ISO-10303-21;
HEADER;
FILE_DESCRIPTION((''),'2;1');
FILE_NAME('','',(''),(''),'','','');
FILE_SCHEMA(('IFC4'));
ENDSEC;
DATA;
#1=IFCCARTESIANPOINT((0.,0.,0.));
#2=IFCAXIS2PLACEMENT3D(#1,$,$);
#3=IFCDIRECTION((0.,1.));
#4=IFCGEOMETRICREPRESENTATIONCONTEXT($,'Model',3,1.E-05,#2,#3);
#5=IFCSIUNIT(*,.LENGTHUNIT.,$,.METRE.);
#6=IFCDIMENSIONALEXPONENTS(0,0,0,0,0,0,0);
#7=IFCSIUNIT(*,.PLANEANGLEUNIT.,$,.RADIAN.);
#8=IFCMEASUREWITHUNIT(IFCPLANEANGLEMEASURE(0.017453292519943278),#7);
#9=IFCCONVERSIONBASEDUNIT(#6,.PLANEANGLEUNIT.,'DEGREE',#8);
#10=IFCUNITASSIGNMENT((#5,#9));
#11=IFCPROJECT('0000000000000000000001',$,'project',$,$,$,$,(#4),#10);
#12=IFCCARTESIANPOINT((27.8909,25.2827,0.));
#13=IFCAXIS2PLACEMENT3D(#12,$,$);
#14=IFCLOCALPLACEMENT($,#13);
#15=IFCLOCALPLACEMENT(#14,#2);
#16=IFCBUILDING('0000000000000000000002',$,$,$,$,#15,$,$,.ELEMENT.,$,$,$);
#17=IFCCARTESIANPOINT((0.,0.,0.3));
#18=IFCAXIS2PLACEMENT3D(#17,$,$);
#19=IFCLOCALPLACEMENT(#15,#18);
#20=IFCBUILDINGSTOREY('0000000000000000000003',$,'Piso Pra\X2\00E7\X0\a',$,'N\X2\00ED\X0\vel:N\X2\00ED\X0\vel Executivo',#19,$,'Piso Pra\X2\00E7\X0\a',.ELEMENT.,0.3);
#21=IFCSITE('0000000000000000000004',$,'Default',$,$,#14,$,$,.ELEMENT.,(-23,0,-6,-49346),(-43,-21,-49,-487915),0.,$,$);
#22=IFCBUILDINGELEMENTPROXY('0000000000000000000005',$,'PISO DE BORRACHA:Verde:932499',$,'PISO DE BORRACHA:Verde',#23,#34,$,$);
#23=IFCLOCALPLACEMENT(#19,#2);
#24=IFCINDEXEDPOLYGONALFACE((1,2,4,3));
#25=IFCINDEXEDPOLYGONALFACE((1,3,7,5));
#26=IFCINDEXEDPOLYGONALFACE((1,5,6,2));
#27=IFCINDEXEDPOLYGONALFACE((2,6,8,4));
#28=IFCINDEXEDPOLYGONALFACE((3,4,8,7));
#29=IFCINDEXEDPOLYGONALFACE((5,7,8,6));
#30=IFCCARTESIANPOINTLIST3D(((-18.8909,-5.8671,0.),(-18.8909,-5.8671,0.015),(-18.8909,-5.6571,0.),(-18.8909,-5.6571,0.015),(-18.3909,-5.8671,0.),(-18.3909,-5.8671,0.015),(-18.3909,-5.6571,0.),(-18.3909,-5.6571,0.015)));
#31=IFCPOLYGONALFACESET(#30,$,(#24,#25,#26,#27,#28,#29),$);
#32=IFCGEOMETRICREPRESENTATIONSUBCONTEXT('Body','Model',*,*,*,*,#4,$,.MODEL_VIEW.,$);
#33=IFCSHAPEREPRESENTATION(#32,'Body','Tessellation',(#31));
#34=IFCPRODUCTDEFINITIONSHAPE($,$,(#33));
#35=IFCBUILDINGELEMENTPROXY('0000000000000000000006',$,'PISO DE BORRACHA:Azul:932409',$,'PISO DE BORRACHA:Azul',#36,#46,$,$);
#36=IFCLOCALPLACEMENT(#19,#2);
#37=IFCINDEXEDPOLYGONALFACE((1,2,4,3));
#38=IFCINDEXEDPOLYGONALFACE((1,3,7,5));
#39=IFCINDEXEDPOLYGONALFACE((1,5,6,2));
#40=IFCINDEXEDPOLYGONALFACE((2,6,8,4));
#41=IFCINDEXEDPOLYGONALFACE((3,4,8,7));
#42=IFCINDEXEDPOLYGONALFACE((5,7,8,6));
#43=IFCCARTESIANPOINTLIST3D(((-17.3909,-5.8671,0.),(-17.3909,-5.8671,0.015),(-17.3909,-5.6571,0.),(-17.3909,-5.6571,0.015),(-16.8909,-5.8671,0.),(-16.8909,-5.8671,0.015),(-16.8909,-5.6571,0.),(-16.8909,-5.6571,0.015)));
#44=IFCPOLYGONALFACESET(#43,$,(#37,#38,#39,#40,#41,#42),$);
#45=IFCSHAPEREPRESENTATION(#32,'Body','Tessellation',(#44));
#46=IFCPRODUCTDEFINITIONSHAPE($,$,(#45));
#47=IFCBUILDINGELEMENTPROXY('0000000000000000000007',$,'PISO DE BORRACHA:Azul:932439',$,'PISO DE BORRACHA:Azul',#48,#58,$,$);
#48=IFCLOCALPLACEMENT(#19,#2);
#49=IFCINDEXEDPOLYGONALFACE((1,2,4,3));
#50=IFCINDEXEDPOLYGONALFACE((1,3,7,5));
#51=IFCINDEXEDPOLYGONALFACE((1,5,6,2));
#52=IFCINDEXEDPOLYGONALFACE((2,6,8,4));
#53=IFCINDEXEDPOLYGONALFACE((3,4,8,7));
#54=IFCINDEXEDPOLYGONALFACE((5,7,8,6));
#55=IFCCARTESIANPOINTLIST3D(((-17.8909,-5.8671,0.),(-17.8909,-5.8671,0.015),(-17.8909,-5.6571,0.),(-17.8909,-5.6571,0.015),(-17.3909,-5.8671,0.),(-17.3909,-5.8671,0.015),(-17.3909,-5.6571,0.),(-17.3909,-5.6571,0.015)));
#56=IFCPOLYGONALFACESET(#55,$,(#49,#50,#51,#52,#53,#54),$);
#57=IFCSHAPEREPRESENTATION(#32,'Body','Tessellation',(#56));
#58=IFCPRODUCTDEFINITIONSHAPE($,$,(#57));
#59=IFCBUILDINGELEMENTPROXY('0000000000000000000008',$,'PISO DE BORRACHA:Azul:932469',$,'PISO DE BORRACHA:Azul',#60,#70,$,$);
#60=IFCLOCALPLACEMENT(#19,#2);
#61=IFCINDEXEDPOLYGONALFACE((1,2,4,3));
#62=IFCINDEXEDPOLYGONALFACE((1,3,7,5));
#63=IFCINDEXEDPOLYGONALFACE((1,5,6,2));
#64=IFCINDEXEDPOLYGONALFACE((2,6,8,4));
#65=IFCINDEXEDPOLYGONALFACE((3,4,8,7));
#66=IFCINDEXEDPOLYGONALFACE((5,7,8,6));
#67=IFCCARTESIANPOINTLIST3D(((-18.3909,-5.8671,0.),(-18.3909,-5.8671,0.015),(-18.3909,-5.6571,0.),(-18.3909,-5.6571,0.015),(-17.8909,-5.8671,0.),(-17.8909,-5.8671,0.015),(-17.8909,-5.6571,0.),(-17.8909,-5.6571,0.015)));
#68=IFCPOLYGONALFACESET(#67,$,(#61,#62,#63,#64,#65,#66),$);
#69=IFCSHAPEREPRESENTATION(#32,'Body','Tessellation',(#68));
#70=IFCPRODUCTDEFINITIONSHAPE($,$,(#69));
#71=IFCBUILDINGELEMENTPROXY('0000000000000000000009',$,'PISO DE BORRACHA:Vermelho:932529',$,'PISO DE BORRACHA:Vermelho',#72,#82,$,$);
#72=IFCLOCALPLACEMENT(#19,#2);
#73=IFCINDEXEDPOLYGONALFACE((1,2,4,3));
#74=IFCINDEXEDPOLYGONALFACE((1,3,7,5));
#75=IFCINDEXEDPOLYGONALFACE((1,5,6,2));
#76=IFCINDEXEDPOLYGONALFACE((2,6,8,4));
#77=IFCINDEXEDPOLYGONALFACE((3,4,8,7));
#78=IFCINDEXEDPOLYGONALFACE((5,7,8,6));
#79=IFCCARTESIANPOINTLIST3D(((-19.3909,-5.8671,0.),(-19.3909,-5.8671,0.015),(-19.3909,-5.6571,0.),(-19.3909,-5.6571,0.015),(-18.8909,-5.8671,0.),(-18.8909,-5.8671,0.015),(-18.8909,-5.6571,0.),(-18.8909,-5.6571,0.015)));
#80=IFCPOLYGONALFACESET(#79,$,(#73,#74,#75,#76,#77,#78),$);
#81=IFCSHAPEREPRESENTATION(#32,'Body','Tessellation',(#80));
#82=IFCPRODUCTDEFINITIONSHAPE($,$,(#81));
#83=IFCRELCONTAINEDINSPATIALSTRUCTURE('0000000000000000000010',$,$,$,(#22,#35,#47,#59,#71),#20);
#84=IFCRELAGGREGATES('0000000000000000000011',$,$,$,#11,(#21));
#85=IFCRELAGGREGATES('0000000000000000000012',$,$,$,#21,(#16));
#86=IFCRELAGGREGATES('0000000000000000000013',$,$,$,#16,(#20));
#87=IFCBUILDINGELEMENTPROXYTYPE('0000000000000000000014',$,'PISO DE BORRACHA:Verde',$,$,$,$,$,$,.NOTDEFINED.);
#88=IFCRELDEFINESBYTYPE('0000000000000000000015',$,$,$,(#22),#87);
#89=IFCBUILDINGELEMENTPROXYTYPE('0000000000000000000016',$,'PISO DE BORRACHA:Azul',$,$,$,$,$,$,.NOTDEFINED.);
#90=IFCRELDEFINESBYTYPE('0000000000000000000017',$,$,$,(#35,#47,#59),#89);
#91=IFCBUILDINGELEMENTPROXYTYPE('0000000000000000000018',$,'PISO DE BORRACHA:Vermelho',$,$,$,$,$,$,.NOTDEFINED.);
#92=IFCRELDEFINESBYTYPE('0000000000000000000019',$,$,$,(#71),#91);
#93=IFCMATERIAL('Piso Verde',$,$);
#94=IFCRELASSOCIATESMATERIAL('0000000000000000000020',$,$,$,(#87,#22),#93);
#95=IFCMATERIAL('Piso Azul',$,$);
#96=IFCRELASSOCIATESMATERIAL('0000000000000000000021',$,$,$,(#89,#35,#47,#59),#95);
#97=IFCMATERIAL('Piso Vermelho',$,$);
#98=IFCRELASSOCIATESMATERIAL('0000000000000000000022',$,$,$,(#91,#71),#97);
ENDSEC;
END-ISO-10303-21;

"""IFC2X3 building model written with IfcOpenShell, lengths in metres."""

from ifc_helpers import new_model, entity, si_unit, converted_unit, direction, frame, frame_2d, origin, place, context, subcontext, project, spatial, rectangle, extrude, source, transform, mapped, material, type_object, type_shapes, element, save


model = new_model("IFC2X3")

# Units and contexts
model_context = context("Model", 3, precision=1e-05, world=origin(), true_north=direction((0.0, 1.0)))
body_context = subcontext(model_context, "Body", "Model", "MODEL_VIEW")
ifc_project = project(units=[si_unit("LENGTHUNIT", "METRE"), converted_unit("PLANEANGLEUNIT", "DEGREE", entity("IfcPlaneAngleMeasure", 0.017453292519943278), si_unit("PLANEANGLEUNIT", "RADIAN"), dimensions=[0, 0, 0, 0, 0, 0, 0])], contexts=[model_context])

# Site, building, storey
site_placement = place(None, frame((27.8909, 25.2827, 0.0)))
site = spatial("IfcSite", under=ifc_project, at=site_placement, Name="Default", CompositionType="ELEMENT", RefLatitude=(-23, 0, -6, -49346), RefLongitude=(-43, -21, -49, -487915), RefElevation=0.0)
building_placement = place(site_placement, origin())
building = spatial("IfcBuilding", under=site, at=building_placement, CompositionType="ELEMENT")
storey_placement = place(building_placement, frame((0.0, 0.0, 0.3)))
storey = spatial("IfcBuildingStorey", under=building, at=storey_placement, Name="Piso Praça", ObjectType="Nível:Nível Executivo", LongName="Piso Praça", CompositionType="ELEMENT", Elevation=0.3)

# Building element proxies
ifc_material_1 = material(Name="Piso Verde")
ifc_material_2 = material(Name="Piso Azul")
ifc_material_3 = material(Name="Piso Vermelho")
building_element_proxy_type_1 = type_object("IfcBuildingElementProxyType", Name="PISO DE BORRACHA:Verde", PredefinedType="NOTDEFINED", material=ifc_material_1)
shared_shape_1 = source(origin(), body_context, "Body", "SweptSolid", [
    extrude(rectangle(XDim=0.21, YDim=0.5, at=frame_2d((0.0, 0.0), x_axis=(1.0, 0.0))), frame((0.105, 0.25, 0.0), z_axis=(0.0, 0.0, 1.0), x_axis=(-1.0, 0.0, 0.0)), (0.0, 0.0, 1.0), 0.015),
])
type_shapes(building_element_proxy_type_1, [shared_shape_1])
for number, where, z_axis, x_axis, name in (
    (1, (-18.8909, -5.6571, 0.0), (0.0, 0.0, 1.0), (0.0, -1.0, 0.0), "PISO DE BORRACHA:Verde:932499"),
):
    element("IfcBuildingElementProxy", number, at=place(storey_placement, frame(where, z_axis=z_axis, x_axis=x_axis)), inside=storey, type_object=building_element_proxy_type_1, material=ifc_material_1, Name=name, ObjectType="PISO DE BORRACHA:Verde", context=body_context, shape_type="MappedRepresentation", body=[
        mapped(shared_shape_1, transform((0.0, 0.0, 0.0), scale=1.0)),
    ])
building_element_proxy_type_2 = type_object("IfcBuildingElementProxyType", Name="PISO DE BORRACHA:Azul", PredefinedType="NOTDEFINED", material=ifc_material_2)
shared_shape_2 = source(origin(), body_context, "Body", "SweptSolid", [
    extrude(rectangle(XDim=0.21, YDim=0.5, at=frame_2d((0.0, 0.0), x_axis=(1.0, 0.0))), frame((0.105, 0.25, 0.0), z_axis=(0.0, 0.0, 1.0), x_axis=(-1.0, 0.0, 0.0)), (0.0, 0.0, 1.0), 0.015),
])
type_shapes(building_element_proxy_type_2, [shared_shape_2])
for number, where, z_axis, x_axis, name in (
    (2, (-17.3909, -5.6571, 0.0), (0.0, 0.0, 1.0), (0.0, -1.0, 0.0), "PISO DE BORRACHA:Azul:932409"),
    (3, (-17.8909, -5.6571, 0.0), (0.0, 0.0, 1.0), (0.0, -1.0, 0.0), "PISO DE BORRACHA:Azul:932439"),
    (4, (-18.3909, -5.6571, 0.0), (0.0, 0.0, 1.0), (0.0, -1.0, 0.0), "PISO DE BORRACHA:Azul:932469"),
):
    element("IfcBuildingElementProxy", number, at=place(storey_placement, frame(where, z_axis=z_axis, x_axis=x_axis)), inside=storey, type_object=building_element_proxy_type_2, material=ifc_material_2, Name=name, ObjectType="PISO DE BORRACHA:Azul", context=body_context, shape_type="MappedRepresentation", body=[
        mapped(shared_shape_2, transform((0.0, 0.0, 0.0), scale=1.0)),
    ])
building_element_proxy_type_3 = type_object("IfcBuildingElementProxyType", Name="PISO DE BORRACHA:Vermelho", PredefinedType="NOTDEFINED", material=ifc_material_3)
shared_shape_3 = source(origin(), body_context, "Body", "SweptSolid", [
    extrude(rectangle(XDim=0.21, YDim=0.5, at=frame_2d((0.0, 0.0), x_axis=(1.0, 0.0))), frame((0.105, 0.25, 0.0), z_axis=(0.0, 0.0, 1.0), x_axis=(-1.0, 0.0, 0.0)), (0.0, 0.0, 1.0), 0.015),
])
type_shapes(building_element_proxy_type_3, [shared_shape_3])
proxy_1_placement = place(storey_placement, frame((-19.3909, -5.6571, 0.0), z_axis=(0.0, 0.0, 1.0), x_axis=(0.0, -1.0, 0.0)))
element("IfcBuildingElementProxy", 5, at=proxy_1_placement, inside=storey, type_object=building_element_proxy_type_3, material=ifc_material_3, Name="PISO DE BORRACHA:Vermelho:932529", ObjectType="PISO DE BORRACHA:Vermelho", context=body_context, shape_type="MappedRepresentation", body=[
    mapped(shared_shape_3, transform((0.0, 0.0, 0.0), scale=1.0)),
])

save(model, "model.ifc")
